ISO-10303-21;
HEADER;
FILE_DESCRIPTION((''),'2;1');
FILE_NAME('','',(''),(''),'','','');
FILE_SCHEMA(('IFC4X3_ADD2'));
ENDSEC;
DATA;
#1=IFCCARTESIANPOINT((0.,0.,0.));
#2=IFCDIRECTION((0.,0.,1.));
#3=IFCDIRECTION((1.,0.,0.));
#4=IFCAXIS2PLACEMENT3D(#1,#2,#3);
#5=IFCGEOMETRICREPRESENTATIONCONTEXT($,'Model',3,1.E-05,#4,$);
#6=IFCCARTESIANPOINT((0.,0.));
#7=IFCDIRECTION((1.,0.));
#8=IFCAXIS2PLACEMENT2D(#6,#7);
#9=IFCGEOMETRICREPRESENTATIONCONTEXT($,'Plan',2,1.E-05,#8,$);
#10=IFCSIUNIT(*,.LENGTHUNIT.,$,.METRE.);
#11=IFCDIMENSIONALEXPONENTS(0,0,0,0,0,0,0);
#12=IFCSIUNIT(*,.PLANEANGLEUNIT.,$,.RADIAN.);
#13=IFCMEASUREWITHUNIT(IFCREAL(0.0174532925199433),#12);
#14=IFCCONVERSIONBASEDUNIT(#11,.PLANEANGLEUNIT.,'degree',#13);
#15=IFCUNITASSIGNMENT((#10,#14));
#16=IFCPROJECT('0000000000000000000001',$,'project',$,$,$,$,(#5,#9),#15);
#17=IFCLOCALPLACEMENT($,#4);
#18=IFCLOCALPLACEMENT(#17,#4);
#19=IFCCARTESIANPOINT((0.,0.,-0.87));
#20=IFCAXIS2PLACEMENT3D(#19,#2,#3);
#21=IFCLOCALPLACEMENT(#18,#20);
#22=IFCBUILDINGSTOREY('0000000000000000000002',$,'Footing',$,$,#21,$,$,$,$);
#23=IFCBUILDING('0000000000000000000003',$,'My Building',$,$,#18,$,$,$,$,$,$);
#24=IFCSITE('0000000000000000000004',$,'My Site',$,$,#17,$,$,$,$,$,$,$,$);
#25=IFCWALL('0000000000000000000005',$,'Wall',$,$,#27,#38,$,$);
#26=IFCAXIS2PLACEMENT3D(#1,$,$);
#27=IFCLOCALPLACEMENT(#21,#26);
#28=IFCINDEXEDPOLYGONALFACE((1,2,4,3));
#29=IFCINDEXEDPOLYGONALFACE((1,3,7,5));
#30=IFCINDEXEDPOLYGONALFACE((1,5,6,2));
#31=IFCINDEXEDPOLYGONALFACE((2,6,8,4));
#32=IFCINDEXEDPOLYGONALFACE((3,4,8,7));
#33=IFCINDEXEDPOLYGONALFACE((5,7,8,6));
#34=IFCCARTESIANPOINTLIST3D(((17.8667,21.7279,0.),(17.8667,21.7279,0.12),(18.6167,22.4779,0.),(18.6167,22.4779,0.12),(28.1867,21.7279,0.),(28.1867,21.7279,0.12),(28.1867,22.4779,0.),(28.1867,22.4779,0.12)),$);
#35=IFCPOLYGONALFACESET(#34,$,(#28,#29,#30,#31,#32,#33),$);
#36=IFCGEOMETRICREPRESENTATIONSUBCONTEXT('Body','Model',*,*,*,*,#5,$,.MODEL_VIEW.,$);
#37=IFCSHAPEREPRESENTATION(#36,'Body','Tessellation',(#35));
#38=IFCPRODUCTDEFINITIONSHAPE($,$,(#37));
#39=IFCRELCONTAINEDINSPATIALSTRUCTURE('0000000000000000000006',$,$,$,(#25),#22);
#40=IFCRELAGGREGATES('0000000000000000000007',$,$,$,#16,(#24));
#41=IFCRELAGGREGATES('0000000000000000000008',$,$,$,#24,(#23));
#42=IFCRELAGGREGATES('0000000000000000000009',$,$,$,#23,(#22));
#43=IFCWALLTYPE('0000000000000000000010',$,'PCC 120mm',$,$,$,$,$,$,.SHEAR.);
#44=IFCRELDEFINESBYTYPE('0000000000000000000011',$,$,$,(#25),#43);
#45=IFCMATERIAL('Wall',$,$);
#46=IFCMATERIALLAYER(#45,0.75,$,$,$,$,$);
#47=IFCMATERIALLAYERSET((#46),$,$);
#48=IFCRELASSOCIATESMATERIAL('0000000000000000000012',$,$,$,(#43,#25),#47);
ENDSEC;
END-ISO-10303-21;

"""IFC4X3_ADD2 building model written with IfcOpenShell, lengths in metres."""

from ifc_helpers import new_model, entity, si_unit, converted_unit, frame, origin_with_axes, origin_2d_with_axis, place, context, subcontext, project, spatial, line, indexed_curve, outline, extrude, material, layer, layer_set, layer_usage, type_object, element, save


model = new_model("IFC4X3_ADD2")

# Units and contexts
model_context = context("Model", 3, precision=1e-05, world=origin_with_axes())
plan_context = context("Plan", 2, precision=1e-05, world=origin_2d_with_axis())
body_context = subcontext(model_context, "Body", "Model", "MODEL_VIEW")
ifc_project = project(units=[si_unit("LENGTHUNIT", "METRE"), converted_unit("PLANEANGLEUNIT", "degree", entity("IfcReal", 0.0174532925199433), si_unit("PLANEANGLEUNIT", "RADIAN"), dimensions=[0, 0, 0, 0, 0, 0, 0])], contexts=[model_context, plan_context])

# Site, building, storey
site_placement = place(None, origin_with_axes())
site = spatial("IfcSite", under=ifc_project, at=site_placement, Name="My Site")
building_placement = place(site_placement, origin_with_axes())
building = spatial("IfcBuilding", under=site, at=building_placement, Name="My Building")
storey_placement = place(building_placement, frame((0.0, 0.0, -0.87), z_axis=(0.0, 0.0, 1.0), x_axis=(1.0, 0.0, 0.0)))
storey = spatial("IfcBuildingStorey", under=building, at=storey_placement, Name="Footing")

# Wall
ifc_material_1 = material(Name="Wall")
ifc_layer_1 = layer(ifc_material_1, 0.75)
ifc_layer_set_1 = layer_set([ifc_layer_1])
wall_type_1 = type_object("IfcWallType", Name="PCC 120mm", PredefinedType="SHEAR", material=ifc_layer_set_1)
ifc_layer_usage_1 = layer_usage(ifc_layer_set_1, "AXIS2", "POSITIVE", 0.0)
wall_1_placement = place(storey_placement, frame((18.6167, 21.7279, 0.0), z_axis=(0.0, 0.0, 1.0), x_axis=(1.0, -0.000001, 0.0)))
element("IfcWall", 1, at=wall_1_placement, inside=storey, type_object=wall_type_1, material=ifc_layer_usage_1, Name="Wall", context=body_context, shape_type="SweptSolid", body=[
    extrude(outline(indexed_curve([(-0.75, 0.0), (0.0, 0.75), (9.57, 0.75), (9.57, 0.0)], segments=[line(1, 2, 3, 4, 1)])), origin_with_axes(), (0.0, 0.0, 1.0), 0.12),
])

save(model, "model.ifc")
